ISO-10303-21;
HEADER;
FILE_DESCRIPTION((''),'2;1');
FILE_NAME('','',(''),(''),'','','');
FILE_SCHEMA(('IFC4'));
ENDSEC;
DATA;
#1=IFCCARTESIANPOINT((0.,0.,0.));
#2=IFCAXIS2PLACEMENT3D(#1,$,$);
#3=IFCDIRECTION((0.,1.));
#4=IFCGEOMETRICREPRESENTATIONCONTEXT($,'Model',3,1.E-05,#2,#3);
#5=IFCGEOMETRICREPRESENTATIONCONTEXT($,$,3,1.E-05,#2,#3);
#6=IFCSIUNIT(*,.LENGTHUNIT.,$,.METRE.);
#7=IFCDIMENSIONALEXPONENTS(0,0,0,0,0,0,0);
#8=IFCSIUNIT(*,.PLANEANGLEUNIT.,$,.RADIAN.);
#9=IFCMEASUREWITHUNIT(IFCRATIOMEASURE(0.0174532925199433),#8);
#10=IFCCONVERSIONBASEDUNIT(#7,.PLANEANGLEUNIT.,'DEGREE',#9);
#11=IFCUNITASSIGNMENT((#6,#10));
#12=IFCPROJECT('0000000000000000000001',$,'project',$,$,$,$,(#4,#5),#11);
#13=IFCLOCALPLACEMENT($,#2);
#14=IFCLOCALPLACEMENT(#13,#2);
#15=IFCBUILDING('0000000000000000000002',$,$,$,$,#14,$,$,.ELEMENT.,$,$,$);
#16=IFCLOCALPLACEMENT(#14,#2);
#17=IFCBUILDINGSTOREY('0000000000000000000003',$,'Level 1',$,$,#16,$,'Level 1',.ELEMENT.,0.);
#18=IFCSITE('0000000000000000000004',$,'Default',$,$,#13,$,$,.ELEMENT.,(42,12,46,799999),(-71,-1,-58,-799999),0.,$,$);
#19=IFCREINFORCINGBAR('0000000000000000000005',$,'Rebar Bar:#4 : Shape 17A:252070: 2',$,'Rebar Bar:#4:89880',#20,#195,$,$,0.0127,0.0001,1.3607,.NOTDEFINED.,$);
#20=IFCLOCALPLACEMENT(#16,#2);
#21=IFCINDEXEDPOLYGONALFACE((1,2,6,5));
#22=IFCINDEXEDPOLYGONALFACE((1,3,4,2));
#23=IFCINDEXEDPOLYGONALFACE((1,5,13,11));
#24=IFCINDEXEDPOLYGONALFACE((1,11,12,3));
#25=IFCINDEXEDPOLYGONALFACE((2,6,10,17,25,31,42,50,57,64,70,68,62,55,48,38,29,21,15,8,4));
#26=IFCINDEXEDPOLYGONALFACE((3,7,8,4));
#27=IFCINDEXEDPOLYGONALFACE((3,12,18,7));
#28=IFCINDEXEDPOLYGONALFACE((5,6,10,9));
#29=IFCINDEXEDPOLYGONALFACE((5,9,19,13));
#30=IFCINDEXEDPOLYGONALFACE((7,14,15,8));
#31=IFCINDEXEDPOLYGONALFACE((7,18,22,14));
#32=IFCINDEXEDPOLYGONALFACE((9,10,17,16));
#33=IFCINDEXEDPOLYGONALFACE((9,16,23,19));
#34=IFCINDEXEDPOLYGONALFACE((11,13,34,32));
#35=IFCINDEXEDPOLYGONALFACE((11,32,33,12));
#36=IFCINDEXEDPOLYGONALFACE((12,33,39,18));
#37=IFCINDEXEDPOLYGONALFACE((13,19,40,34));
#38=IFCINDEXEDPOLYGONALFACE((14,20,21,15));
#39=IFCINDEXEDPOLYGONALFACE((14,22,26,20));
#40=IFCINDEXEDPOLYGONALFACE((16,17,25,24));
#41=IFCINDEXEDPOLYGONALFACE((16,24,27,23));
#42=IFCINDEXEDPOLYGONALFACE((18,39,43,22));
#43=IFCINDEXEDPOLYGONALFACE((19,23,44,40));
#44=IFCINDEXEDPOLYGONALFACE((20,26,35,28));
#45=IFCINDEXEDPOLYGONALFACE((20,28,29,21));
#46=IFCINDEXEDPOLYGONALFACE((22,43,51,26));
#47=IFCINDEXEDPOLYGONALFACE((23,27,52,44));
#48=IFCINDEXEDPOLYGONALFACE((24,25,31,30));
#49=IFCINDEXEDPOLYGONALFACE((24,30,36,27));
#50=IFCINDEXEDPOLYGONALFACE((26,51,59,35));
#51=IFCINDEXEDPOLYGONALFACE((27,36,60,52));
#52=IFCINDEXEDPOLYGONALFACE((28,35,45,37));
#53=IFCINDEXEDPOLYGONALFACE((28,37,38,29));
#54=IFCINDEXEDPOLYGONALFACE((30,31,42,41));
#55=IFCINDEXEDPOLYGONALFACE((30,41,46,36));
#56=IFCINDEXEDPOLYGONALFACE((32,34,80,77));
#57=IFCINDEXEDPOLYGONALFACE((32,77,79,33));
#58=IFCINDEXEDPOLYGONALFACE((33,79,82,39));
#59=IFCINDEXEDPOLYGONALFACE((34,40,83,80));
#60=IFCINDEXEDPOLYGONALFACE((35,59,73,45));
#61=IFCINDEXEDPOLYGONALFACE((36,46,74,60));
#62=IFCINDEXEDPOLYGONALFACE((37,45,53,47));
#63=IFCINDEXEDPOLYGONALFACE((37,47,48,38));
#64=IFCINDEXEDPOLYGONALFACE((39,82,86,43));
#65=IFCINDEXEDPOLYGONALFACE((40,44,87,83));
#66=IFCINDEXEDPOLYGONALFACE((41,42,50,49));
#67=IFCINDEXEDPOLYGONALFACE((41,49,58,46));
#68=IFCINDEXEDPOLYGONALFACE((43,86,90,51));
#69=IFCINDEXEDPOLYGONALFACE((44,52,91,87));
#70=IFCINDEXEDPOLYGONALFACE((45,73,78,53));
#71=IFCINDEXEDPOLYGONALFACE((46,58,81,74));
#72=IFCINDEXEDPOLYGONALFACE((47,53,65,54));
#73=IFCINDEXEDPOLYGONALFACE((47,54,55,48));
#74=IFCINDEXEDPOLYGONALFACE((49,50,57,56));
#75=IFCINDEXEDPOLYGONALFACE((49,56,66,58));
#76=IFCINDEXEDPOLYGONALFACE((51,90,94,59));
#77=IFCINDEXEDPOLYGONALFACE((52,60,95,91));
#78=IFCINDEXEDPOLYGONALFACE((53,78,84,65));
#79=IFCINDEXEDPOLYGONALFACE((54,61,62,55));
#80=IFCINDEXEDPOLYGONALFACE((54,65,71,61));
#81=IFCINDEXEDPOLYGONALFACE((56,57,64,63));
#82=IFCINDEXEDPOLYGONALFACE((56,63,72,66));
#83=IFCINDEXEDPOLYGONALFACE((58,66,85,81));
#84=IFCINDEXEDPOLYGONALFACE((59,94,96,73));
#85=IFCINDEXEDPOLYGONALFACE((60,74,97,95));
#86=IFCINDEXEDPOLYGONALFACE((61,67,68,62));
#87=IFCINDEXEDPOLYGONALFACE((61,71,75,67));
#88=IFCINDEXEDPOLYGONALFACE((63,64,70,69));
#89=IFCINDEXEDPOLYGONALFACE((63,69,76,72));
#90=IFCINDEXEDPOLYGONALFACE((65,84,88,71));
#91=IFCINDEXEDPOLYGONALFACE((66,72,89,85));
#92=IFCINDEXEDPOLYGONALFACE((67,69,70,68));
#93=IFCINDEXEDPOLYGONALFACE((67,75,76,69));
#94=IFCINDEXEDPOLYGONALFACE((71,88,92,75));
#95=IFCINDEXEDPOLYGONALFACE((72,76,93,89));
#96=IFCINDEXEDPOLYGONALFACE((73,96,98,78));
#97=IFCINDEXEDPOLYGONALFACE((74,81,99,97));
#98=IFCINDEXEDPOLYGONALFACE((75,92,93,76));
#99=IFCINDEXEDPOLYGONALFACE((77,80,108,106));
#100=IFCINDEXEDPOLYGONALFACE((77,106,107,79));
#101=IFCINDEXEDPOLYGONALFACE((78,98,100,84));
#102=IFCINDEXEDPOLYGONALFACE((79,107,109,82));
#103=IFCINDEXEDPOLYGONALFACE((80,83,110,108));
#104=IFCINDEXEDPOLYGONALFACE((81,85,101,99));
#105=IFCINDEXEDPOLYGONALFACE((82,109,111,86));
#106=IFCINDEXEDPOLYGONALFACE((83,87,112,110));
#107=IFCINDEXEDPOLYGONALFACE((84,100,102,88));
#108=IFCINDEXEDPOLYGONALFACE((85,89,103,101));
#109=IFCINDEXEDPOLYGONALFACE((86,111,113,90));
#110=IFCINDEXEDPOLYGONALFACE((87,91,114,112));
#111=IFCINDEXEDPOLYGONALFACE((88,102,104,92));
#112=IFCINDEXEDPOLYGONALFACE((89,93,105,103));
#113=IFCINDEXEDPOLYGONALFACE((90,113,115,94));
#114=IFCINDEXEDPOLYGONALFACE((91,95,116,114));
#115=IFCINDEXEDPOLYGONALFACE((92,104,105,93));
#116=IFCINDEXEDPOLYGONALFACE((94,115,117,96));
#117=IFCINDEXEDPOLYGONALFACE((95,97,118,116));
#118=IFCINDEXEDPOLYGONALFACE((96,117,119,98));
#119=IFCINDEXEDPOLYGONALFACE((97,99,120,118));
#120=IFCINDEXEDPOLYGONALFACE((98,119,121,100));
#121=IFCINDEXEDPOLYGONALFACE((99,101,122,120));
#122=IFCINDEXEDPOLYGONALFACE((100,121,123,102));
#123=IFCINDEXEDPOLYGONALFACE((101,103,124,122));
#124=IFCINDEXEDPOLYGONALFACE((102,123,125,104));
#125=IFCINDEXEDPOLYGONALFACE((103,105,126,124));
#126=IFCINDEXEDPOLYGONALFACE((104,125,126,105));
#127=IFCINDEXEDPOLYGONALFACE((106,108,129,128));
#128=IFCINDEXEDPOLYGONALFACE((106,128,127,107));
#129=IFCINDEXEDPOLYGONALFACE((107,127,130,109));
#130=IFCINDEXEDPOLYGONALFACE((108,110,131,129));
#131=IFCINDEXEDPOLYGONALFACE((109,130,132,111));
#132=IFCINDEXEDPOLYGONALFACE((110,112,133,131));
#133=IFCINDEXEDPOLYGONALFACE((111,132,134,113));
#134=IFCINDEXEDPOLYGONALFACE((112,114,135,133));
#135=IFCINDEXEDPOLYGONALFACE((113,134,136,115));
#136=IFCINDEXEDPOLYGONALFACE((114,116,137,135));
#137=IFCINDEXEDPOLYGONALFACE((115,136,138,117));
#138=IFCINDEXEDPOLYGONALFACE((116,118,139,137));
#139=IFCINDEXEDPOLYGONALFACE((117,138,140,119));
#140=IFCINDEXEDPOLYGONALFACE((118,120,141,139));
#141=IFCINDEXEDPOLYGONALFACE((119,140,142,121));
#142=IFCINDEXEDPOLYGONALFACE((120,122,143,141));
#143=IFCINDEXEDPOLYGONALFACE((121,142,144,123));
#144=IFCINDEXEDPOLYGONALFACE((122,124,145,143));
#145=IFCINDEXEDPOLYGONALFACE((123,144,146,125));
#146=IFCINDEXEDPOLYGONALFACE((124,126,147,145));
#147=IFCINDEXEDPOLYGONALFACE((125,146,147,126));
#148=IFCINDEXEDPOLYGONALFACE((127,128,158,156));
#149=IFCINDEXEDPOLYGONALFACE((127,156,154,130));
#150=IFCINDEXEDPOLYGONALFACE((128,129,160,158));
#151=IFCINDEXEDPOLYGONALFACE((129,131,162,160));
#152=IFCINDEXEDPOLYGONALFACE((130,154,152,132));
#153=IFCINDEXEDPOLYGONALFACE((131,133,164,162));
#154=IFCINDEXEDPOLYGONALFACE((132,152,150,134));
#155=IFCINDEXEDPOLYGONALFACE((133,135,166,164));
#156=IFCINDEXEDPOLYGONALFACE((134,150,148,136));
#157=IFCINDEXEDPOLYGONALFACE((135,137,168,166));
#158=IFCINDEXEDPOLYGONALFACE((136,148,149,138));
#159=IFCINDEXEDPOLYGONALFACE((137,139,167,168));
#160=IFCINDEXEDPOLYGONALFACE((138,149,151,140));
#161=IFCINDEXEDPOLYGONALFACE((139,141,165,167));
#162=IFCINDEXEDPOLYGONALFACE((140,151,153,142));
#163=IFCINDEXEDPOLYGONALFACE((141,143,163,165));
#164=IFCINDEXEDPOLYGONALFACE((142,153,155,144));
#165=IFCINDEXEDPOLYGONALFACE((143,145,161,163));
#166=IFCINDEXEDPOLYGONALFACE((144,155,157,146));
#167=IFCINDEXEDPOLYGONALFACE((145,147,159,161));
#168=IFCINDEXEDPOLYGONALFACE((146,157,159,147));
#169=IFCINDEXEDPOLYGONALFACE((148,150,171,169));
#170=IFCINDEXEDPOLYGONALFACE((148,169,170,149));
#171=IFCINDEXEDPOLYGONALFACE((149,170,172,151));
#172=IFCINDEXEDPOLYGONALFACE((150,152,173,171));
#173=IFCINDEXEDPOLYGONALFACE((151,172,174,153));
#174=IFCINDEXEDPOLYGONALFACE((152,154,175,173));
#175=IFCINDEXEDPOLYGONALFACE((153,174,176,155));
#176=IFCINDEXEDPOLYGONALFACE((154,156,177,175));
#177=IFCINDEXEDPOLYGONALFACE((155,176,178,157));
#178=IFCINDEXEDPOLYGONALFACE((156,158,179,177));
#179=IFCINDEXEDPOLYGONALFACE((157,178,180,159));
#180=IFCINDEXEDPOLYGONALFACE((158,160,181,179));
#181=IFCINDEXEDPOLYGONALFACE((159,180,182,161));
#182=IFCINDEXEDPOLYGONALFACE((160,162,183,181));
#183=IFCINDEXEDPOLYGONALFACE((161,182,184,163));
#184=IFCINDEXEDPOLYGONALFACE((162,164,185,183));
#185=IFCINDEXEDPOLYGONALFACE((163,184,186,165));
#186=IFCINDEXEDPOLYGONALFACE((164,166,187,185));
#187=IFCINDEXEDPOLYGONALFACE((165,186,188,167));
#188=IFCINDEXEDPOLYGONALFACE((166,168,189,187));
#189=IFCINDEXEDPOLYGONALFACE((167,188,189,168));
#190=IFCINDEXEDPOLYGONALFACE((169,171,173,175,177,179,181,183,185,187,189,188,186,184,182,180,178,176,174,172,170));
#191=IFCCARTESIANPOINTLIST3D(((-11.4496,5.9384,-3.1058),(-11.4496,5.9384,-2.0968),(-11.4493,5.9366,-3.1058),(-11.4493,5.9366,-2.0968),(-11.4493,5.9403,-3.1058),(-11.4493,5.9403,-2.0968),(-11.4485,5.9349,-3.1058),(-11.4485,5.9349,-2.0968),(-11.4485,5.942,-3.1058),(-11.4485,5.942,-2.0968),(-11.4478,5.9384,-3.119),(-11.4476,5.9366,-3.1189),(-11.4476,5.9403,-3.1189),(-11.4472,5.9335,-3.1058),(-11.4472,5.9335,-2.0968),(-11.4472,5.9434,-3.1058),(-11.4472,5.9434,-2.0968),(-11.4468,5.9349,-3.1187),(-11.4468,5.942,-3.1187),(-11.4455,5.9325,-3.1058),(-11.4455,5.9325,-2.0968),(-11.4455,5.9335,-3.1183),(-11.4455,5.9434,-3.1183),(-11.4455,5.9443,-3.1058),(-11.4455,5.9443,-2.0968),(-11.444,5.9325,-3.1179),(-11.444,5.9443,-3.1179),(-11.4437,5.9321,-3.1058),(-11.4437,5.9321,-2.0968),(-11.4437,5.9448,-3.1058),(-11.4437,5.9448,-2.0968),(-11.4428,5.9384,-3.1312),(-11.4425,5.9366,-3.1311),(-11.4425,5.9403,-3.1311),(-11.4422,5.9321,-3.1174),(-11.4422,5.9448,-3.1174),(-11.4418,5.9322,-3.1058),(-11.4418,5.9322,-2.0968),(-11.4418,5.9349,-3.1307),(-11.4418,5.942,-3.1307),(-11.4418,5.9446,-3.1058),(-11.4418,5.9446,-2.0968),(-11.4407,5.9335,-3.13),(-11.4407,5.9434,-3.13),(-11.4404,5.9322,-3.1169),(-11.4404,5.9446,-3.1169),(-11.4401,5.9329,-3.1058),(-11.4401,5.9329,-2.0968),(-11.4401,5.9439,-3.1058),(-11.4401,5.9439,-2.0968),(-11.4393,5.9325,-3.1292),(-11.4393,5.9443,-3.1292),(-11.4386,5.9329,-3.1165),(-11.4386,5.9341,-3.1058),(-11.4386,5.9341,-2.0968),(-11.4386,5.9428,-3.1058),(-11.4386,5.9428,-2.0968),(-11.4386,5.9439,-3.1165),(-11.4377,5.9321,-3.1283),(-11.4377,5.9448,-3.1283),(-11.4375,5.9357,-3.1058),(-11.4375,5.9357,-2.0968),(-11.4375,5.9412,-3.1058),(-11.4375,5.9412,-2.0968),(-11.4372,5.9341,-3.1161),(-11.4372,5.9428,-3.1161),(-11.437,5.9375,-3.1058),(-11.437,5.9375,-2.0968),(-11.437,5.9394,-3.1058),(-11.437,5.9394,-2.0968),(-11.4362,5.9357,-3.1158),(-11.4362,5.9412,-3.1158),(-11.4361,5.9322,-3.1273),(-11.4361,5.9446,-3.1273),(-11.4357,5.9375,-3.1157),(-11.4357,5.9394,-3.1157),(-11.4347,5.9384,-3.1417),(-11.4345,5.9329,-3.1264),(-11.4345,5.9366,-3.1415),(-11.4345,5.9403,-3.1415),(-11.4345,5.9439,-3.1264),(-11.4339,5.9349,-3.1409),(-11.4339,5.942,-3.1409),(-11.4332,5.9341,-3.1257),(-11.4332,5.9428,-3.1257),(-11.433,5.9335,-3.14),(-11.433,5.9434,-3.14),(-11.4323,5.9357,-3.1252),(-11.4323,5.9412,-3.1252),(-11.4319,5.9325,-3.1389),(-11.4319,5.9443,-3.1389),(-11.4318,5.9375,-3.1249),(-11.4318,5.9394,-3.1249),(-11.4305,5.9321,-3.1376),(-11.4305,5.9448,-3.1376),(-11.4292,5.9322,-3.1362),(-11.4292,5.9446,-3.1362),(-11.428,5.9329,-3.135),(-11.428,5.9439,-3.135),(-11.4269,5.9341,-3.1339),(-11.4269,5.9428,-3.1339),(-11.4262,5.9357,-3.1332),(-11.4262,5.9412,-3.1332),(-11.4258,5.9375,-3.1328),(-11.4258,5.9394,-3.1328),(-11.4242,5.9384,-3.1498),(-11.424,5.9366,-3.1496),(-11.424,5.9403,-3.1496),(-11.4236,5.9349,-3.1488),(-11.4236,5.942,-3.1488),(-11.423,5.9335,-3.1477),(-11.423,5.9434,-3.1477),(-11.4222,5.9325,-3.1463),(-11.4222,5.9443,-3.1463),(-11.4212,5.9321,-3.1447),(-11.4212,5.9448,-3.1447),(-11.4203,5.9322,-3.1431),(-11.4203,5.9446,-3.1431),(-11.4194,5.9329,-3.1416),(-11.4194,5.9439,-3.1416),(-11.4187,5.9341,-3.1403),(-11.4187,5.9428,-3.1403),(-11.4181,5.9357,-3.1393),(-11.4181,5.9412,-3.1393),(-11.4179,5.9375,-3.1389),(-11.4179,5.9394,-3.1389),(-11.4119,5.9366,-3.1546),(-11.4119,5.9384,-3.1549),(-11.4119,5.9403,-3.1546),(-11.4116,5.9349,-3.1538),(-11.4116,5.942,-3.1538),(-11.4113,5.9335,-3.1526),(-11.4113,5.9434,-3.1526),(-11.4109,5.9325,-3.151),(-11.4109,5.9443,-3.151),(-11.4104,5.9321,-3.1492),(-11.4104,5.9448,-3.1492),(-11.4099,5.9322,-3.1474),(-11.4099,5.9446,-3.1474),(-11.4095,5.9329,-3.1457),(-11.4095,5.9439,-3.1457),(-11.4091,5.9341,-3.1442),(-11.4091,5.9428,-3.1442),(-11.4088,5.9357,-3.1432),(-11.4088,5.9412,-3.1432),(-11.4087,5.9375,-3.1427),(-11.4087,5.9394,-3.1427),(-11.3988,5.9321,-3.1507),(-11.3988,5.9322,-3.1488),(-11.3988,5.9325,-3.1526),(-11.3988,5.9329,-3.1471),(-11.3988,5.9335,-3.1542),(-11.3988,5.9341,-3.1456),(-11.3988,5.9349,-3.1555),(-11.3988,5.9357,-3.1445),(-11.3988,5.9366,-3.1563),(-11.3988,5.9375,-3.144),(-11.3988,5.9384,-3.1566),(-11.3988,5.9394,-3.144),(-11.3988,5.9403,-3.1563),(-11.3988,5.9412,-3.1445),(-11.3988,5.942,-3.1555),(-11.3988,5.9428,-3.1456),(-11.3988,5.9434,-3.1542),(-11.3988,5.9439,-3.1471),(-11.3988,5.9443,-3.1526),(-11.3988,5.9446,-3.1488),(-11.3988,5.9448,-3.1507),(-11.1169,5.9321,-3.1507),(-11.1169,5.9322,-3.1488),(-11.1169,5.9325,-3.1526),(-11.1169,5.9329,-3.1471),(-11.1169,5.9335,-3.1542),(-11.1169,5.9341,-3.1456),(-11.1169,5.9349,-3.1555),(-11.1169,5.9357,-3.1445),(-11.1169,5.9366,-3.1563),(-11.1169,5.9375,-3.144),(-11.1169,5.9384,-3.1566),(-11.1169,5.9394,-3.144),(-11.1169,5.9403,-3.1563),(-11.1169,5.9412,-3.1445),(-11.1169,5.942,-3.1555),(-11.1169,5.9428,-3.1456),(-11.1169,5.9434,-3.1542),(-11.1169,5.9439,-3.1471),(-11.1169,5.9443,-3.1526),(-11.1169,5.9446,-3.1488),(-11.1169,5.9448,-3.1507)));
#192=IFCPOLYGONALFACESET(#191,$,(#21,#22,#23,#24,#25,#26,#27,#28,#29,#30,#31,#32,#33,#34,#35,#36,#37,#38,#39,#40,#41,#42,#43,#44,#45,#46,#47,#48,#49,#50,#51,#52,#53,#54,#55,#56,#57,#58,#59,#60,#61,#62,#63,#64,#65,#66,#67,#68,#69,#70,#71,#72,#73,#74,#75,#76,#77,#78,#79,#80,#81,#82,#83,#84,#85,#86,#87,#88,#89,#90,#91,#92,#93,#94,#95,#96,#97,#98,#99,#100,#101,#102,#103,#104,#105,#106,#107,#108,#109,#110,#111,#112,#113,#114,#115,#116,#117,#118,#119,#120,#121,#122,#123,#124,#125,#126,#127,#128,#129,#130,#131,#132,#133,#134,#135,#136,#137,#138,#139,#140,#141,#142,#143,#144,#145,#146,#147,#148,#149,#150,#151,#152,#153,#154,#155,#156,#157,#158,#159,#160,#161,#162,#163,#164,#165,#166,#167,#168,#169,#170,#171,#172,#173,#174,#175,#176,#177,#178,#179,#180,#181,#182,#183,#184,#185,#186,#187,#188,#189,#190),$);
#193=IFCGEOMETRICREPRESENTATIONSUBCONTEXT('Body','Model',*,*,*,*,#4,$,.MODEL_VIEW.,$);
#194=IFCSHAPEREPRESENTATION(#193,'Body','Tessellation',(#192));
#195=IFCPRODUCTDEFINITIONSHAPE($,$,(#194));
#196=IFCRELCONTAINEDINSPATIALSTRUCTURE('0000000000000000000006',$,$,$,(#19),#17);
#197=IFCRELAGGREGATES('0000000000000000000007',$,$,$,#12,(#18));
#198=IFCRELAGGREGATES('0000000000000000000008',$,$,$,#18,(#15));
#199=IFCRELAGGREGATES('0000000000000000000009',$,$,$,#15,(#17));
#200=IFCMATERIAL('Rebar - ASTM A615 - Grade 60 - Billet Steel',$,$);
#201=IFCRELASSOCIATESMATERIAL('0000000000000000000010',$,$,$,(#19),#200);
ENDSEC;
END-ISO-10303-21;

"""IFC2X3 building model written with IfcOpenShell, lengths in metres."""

from ifc_helpers import new_model, entity, si_unit, converted_unit, direction, origin, place, context, subcontext, project, spatial, material, element, save


model = new_model("IFC2X3")

# Units and contexts
model_context = context("Model", 3, precision=1e-05, world=origin(), true_north=direction((0.0, 1.0)))
context_of_model = context(None, 3, precision=1e-05, world=origin(), true_north=direction((0.0, 1.0)))
body_context = subcontext(model_context, "Body", "Model", "MODEL_VIEW")
ifc_project = project(units=[si_unit("LENGTHUNIT", "METRE"), converted_unit("PLANEANGLEUNIT", "DEGREE", entity("IfcRatioMeasure", 0.0174532925199433), si_unit("PLANEANGLEUNIT", "RADIAN"), dimensions=[0, 0, 0, 0, 0, 0, 0])], contexts=[model_context, context_of_model])

# Site, building, storey
site_placement = place(None, origin())
site = spatial("IfcSite", under=ifc_project, at=site_placement, Name="Default", CompositionType="ELEMENT", RefLatitude=(42, 12, 46, 799999), RefLongitude=(-71, -1, -58, -799999), RefElevation=0.0)
building_placement = place(site_placement, origin())
building = spatial("IfcBuilding", under=site, at=building_placement, CompositionType="ELEMENT")
storey_placement = place(building_placement, origin())
storey = spatial("IfcBuildingStorey", under=building, at=storey_placement, Name="Level 1", LongName="Level 1", CompositionType="ELEMENT", Elevation=0.0)

# Reinforcing bar
ifc_material_1 = material(Name="Rebar - ASTM A615 - Grade 60 - Billet Steel")
reinforcing_bar_1_placement = place(storey_placement, origin())
element("IfcReinforcingBar", 1, at=reinforcing_bar_1_placement, inside=storey, material=ifc_material_1, Name="Rebar Bar:#4 : Shape 17A:252070: 2", ObjectType="Rebar Bar:#4:89880", BarLength=1.3607, BarRole="NOTDEFINED", CrossSectionArea=0.0001, NominalDiameter=0.0127, context=body_context, shape_type="AdvancedSweptSolid", body=[
    entity("IfcSweptDiskSolid", entity("IfcCompositeCurve", [entity("IfcCompositeCurveSegment", "CONTINUOUS", True, entity("IfcPolyline", [entity("IfcCartesianPoint", [-11.4432, 5.9384, -2.0968]), entity("IfcCartesianPoint", [-11.4432, 5.9384, -3.1058])])), entity("IfcCompositeCurveSegment", "CONTINUOUS", True, entity("IfcTrimmedCurve", entity("IfcCircle", entity("IfcAxis2Placement3D", entity("IfcCartesianPoint", [-11.3988, 5.9384, -3.1058]), entity("IfcDirection", [0.0, -1.0, 0.0]), entity("IfcDirection", [0.0, 0.0, -1.0])), 0.0445), [entity("IfcParameterValue", 270.0)], [entity("IfcParameterValue", 360.0)], True, "PARAMETER")), entity("IfcCompositeCurveSegment", "CONTINUOUS", True, entity("IfcPolyline", [entity("IfcCartesianPoint", [-11.3988, 5.9384, -3.1503]), entity("IfcCartesianPoint", [-11.1169, 5.9384, -3.1503])]))], False), 0.0063, None, 0.0, 92.0),
])

save(model, "model.ifc")
